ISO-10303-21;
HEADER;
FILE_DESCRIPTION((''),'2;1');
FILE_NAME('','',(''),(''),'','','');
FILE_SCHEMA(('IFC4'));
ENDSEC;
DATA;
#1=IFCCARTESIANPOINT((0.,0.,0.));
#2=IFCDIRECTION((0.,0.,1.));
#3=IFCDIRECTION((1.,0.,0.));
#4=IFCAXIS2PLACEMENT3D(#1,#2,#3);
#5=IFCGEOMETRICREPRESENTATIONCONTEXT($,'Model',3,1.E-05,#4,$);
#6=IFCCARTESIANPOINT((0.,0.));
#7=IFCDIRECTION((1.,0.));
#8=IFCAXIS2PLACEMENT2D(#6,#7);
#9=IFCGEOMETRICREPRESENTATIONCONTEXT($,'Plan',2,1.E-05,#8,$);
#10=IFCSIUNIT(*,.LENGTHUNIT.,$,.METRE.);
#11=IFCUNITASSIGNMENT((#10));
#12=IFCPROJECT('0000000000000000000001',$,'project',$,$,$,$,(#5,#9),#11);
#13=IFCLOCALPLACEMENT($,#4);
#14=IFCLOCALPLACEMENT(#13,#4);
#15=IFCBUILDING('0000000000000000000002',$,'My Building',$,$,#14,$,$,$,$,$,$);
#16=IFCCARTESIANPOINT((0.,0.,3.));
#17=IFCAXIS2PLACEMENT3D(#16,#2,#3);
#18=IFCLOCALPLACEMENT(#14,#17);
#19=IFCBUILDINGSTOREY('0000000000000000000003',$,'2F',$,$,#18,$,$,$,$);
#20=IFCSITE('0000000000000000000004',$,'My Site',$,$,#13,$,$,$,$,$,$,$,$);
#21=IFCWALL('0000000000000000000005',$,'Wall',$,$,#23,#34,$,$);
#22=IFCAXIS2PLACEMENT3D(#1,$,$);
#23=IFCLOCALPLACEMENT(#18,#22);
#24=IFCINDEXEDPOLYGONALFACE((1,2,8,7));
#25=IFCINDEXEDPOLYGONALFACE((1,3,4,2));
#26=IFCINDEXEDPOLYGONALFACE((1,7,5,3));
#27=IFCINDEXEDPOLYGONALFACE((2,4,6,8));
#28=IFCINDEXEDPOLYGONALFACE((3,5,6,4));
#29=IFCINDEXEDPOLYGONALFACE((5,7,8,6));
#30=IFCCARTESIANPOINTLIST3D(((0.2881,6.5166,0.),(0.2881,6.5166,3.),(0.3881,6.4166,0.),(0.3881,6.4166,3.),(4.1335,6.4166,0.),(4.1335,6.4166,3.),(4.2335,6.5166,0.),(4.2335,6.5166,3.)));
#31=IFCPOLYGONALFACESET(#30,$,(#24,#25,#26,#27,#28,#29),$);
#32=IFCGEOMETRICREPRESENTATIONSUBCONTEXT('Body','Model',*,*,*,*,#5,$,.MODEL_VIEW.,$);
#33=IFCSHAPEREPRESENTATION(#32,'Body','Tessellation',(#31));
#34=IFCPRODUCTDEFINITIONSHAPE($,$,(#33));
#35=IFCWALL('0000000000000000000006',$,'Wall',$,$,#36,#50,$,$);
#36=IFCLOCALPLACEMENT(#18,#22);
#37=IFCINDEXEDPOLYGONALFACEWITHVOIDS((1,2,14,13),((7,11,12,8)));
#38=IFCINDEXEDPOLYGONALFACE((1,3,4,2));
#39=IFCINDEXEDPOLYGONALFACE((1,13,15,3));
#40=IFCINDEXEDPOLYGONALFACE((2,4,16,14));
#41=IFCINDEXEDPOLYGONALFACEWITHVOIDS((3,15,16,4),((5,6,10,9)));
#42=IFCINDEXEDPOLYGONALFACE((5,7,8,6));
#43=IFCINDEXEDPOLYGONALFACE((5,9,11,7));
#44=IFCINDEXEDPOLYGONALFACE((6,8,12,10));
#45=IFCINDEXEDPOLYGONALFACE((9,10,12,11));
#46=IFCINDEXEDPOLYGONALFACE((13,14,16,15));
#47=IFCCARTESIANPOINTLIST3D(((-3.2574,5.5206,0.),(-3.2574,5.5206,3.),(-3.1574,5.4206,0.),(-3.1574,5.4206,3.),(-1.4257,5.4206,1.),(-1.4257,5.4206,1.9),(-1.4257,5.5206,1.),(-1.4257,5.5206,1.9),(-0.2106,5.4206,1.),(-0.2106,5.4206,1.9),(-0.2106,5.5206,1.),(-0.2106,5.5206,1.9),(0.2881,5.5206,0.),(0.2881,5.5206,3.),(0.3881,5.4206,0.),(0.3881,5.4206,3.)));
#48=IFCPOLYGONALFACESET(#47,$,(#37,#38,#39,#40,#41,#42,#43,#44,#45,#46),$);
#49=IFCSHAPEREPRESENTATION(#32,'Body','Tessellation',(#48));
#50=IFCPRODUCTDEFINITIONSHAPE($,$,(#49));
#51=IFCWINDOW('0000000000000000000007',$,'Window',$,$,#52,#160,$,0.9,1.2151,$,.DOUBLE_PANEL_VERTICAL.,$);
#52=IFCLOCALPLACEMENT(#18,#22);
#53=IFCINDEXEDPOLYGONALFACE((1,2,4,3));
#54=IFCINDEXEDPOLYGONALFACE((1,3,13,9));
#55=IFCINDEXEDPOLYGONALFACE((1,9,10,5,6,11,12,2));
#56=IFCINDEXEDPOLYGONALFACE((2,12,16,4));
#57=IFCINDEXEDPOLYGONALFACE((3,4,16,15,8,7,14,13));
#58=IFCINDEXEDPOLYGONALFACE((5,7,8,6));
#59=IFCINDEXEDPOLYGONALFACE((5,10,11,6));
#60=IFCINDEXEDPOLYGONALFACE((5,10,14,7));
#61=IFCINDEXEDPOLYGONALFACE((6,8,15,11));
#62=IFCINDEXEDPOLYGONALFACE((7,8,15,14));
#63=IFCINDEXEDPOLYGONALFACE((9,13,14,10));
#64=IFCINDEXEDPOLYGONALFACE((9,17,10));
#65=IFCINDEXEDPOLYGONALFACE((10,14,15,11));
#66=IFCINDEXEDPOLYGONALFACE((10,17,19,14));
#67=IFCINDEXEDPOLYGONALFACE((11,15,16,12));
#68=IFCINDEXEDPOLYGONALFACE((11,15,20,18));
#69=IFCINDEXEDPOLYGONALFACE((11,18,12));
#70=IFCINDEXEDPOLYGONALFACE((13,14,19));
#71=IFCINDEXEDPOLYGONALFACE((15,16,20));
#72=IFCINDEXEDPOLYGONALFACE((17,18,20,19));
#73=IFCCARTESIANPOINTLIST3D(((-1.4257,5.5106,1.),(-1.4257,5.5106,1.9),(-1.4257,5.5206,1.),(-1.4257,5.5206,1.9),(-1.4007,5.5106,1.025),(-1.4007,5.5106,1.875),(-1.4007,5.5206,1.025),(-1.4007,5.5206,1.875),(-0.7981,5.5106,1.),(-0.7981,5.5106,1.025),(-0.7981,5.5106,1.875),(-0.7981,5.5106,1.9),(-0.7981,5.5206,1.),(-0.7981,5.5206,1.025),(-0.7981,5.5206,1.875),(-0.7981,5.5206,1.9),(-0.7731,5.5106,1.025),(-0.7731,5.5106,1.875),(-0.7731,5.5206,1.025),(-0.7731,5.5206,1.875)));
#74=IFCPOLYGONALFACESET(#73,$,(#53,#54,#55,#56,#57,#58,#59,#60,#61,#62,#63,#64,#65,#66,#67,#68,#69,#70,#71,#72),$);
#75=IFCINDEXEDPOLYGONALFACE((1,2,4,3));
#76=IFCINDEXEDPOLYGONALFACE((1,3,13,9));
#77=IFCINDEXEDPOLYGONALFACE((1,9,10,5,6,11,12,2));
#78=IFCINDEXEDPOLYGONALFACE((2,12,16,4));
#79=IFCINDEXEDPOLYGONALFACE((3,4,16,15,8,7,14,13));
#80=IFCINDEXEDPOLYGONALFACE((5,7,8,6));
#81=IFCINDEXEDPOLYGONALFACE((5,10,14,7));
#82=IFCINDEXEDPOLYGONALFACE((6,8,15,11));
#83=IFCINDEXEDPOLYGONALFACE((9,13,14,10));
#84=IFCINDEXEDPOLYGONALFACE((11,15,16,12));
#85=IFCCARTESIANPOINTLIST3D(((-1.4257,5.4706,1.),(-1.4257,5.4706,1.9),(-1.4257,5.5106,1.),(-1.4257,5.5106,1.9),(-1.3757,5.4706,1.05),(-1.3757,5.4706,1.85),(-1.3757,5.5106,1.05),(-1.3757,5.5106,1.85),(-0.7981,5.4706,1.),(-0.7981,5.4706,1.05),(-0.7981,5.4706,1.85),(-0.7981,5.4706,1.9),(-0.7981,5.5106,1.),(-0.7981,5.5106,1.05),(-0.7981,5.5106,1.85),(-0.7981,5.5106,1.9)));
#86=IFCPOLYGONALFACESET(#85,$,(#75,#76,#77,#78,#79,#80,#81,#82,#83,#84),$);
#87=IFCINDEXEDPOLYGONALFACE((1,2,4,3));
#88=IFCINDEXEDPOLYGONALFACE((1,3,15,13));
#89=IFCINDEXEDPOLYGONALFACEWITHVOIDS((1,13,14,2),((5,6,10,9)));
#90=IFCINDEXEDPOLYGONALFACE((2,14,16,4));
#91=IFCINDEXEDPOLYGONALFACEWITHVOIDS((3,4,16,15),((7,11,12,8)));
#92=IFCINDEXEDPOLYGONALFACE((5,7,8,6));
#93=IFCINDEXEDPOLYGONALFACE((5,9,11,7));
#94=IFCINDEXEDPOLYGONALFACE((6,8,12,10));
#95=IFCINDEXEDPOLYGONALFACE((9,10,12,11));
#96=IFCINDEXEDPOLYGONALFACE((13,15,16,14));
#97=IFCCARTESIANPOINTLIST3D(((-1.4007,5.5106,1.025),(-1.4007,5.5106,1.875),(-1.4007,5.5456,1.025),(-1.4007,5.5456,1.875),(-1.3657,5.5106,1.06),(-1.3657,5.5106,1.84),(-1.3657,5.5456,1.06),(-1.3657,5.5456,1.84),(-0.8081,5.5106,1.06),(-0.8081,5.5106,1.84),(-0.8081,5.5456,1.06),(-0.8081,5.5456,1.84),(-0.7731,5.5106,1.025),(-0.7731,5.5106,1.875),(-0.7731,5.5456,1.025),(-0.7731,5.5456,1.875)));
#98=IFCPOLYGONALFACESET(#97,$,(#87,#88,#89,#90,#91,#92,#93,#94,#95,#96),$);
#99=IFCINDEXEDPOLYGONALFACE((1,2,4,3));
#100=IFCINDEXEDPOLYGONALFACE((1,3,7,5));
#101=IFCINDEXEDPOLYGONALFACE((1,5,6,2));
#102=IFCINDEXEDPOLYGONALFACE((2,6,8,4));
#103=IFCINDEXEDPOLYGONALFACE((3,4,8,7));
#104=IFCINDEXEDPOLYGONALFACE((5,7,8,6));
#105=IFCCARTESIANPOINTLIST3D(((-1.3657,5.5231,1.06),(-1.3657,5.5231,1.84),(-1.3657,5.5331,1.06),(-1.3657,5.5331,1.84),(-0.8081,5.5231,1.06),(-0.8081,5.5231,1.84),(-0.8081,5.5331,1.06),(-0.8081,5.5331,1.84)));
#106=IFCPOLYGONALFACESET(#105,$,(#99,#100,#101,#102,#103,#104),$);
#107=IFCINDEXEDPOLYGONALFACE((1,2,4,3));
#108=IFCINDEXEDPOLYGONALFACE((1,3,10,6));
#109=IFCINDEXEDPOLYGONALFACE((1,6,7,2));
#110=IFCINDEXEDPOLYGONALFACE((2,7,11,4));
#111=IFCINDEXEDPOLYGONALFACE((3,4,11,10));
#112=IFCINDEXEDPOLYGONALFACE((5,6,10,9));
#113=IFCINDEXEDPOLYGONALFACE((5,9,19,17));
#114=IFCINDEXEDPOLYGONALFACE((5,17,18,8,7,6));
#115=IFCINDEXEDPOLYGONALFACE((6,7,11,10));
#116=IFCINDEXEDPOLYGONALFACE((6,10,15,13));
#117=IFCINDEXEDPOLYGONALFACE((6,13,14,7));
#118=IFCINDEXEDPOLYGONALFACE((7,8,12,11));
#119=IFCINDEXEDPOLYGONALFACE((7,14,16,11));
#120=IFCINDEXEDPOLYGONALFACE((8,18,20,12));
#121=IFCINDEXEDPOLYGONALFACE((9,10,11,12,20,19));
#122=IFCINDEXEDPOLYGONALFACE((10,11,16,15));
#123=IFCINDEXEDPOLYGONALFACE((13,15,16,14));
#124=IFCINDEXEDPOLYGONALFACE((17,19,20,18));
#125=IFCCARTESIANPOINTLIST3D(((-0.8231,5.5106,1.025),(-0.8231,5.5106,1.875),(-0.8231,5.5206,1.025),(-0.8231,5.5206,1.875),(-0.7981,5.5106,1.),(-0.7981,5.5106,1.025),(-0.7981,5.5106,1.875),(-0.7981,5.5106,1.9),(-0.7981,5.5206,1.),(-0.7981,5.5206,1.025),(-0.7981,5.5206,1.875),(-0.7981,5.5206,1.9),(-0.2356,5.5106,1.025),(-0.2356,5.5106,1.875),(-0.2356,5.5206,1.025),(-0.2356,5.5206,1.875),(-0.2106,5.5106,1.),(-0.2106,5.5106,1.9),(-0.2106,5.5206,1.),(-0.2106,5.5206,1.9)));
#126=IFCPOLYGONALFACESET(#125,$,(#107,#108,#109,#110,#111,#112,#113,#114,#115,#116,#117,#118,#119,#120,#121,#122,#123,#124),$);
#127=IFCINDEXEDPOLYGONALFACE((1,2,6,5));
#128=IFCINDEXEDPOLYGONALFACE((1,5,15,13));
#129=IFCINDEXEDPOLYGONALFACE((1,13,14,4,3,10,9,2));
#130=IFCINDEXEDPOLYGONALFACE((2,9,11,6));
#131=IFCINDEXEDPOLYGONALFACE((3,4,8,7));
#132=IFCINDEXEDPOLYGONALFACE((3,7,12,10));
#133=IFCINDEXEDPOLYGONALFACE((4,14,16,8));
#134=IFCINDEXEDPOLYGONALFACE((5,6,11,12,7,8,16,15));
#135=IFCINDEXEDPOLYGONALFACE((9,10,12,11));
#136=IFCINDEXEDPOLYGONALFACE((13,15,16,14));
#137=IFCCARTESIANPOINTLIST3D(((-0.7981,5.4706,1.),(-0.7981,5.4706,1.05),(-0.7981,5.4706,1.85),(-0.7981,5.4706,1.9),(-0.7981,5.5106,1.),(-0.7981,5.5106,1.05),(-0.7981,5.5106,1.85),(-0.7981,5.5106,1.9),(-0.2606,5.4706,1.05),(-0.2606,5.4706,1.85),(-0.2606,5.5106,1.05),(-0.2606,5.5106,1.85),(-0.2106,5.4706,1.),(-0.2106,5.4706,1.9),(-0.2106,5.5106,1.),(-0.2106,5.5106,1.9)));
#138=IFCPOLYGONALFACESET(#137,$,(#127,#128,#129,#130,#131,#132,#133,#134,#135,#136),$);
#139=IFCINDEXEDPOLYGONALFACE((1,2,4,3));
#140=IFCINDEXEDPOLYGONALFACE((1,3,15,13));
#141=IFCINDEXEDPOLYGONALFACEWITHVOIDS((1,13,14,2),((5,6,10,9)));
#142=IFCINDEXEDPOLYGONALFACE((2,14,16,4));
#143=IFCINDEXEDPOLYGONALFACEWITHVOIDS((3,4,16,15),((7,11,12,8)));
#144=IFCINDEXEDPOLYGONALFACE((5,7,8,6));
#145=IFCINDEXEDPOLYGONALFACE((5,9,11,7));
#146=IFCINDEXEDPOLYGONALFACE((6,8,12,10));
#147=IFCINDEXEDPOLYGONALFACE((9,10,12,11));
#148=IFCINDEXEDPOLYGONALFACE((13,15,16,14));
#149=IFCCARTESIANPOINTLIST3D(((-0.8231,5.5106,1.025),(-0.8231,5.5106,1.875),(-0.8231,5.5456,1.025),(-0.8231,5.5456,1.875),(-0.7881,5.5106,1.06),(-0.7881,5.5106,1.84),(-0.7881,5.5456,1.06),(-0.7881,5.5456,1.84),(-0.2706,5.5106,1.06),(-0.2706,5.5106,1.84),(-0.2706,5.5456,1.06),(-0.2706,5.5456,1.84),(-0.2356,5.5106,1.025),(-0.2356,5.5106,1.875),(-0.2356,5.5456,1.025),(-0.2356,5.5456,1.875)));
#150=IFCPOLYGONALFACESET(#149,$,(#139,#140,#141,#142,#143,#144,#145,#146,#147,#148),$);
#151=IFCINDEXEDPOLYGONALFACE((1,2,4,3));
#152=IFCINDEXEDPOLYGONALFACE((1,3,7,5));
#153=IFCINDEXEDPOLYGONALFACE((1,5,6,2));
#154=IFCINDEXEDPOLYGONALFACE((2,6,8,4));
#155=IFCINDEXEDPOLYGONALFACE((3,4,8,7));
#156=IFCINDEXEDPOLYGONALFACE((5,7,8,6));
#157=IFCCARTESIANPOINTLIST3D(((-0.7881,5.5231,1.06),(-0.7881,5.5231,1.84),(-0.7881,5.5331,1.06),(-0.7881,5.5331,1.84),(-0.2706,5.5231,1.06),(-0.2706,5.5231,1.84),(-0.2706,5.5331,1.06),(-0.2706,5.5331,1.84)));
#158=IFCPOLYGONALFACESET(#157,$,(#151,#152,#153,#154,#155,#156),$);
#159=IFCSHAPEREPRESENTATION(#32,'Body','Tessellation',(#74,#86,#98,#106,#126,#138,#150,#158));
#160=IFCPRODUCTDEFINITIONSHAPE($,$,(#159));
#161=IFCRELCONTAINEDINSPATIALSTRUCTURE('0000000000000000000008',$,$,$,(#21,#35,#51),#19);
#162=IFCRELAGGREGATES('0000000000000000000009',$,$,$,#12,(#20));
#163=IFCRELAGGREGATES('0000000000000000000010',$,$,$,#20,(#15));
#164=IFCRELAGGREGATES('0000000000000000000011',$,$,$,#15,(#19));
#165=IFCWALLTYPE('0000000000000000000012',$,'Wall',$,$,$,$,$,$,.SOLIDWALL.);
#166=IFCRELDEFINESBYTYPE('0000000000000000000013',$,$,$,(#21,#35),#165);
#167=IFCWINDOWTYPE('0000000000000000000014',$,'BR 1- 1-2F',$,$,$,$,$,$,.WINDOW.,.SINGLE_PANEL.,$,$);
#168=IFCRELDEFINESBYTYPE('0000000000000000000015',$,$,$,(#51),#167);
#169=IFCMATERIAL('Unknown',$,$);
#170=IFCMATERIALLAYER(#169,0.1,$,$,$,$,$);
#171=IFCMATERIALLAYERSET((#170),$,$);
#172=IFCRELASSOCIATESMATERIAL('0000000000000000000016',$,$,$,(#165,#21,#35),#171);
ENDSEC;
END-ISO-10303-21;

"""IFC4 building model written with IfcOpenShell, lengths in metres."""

from ifc_helpers import new_model, entity, si_unit, frame, origin_with_axes, origin_2d_with_axis, place, context, subcontext, project, spatial, line, indexed_curve, outline, extrude, shape, source, transform, mapped, material, layer, layer_set, layer_usage, type_object, type_shapes, element, fill, save


model = new_model("IFC4")

# Units and contexts
model_context = context("Model", 3, precision=1e-05, world=origin_with_axes())
plan_context = context("Plan", 2, precision=1e-05, world=origin_2d_with_axis())
body_context_1 = subcontext(model_context, "Body", "Model", "MODEL_VIEW")
body_context_2 = subcontext(plan_context, "Body", "Plan", "PLAN_VIEW")
ifc_project = project(units=[si_unit("LENGTHUNIT", "METRE")], contexts=[model_context, plan_context])

# Site, building, storey
site_placement = place(None, origin_with_axes())
site = spatial("IfcSite", under=ifc_project, at=site_placement, Name="My Site")
building_placement = place(site_placement, origin_with_axes())
building = spatial("IfcBuilding", under=site, at=building_placement, Name="My Building")
storey_placement = place(building_placement, frame((0.0, 0.0, 3.0), z_axis=(0.0, 0.0, 1.0), x_axis=(1.0, 0.0, 0.0)))
storey = spatial("IfcBuildingStorey", under=building, at=storey_placement, Name="2F")

# Shared definitions
ifc_material = material(Name="Unknown")

# Wall
ifc_layer = layer(ifc_material, 0.1)
ifc_layer_set = layer_set([ifc_layer])
ifc_layer_usage_1 = layer_usage(ifc_layer_set, "AXIS2", "POSITIVE", 0.0)
wall_type = type_object("IfcWallType", Name="Wall", PredefinedType="SOLIDWALL", material=ifc_layer_set)
wall_1_placement = place(storey_placement, frame((4.2335, 6.5166, 0.0), z_axis=(0.0, 0.0, 1.0), x_axis=(-1.0, 0.0, 0.0)))
element("IfcWall", 1, at=wall_1_placement, inside=storey, type_object=wall_type, material=ifc_layer_usage_1, Name="Wall", context=body_context_1, shape_type="SweptSolid", body=[
    extrude(outline(indexed_curve([(0.0, 0.0), (0.1, 0.1), (3.8454, 0.1), (3.9454, 0.0)], segments=[line(1, 2, 3, 4, 1)])), origin_with_axes(), (0.0, 0.0, 1.0), 3.0),
])

# Wall, opening, window
ifc_layer_usage_2 = layer_usage(ifc_layer_set, "AXIS2", "POSITIVE", 0.0)
wall_2_placement = place(storey_placement, frame((0.3881, 5.5206, 0.0), z_axis=(0.0, 0.0, 1.0), x_axis=(-1.0, 0.0, 0.0)))
wall_2 = element("IfcWall", 2, at=wall_2_placement, inside=storey, type_object=wall_type, material=ifc_layer_usage_2, Name="Wall", context=body_context_1, shape_type="SweptSolid", body=[
    extrude(outline(indexed_curve([(0.1, 0.0), (0.0, 0.1), (3.5455, 0.1), (3.6455, 0.0)], segments=[line(1, 2, 3, 4, 1)])), origin_with_axes(), (0.0, 0.0, 1.0), 3.0),
])
shared_shape_1 = source(origin_with_axes(), body_context_1, "Body", "SweptSolid", [
    extrude(outline(indexed_curve([(0.0, 0.0), (1.2151, 0.0), (1.2151, 0.9), (0.0, 0.9)], segments=[line(1, 2, 3, 4, 1)])), frame((0.0, -0.6, 0.0), z_axis=(0.0, -1.0, 0.0), x_axis=(1.0, 0.0, 0.0)), (0.0, 0.0, -1.0), 1.2),
])
opening_1_placement = place(wall_2_placement, frame((1.8138, 0.1, 1.0), z_axis=(0.0, 0.0, 1.0), x_axis=(-1.0, 0.0, 0.0)))
opening_1 = element("IfcOpeningElement", 3, at=opening_1_placement, cuts=wall_2, PredefinedType="OPENING", context=body_context_1, shape_type="MappedRepresentation", body=[
    mapped(shared_shape_1, transform((0.0, 0.0, 0.0), x_axis=(1.0, 0.0, 0.0), y_axis=(0.0, 1.0, 0.0), z_axis=(0.0, 0.0, 1.0), scale=1.0)),
])
window_type_1 = type_object("IfcWindowType", Name="BR 1- 1-2F", PartitioningType="SINGLE_PANEL", PredefinedType="WINDOW")
shared_shape_2 = source(origin_with_axes(), body_context_1, "Body", "SweptSolid", [
    extrude(outline(indexed_curve([(0.0, 0.0), (0.6275, 0.0), (0.6275, 0.9), (0.0, 0.9)], segments=[line(1, 2, 3, 4, 1)]), holes=[indexed_curve([(0.025, 0.025), (0.6525, 0.025), (0.6525, 0.875), (0.025, 0.875)], segments=[line(1, 2, 3, 4, 1)])]), frame((0.0, 0.09, 0.0), z_axis=(0.0, -1.0, 0.0), x_axis=(1.0, 0.0, 0.0)), (0.0, 0.0, -1.0), 0.01),
    extrude(outline(indexed_curve([(0.6275, 0.0), (0.0, 0.0), (0.0, 0.9), (0.6275, 0.9), (0.6275, 0.85), (0.05, 0.85), (0.05, 0.05), (0.6275, 0.05)], segments=[line(1, 2, 3, 4, 5, 6, 7, 8, 1)])), frame((0.0, 0.05, 0.0), z_axis=(0.0, -1.0, 0.0), x_axis=(1.0, 0.0, 0.0)), (0.0, 0.0, -1.0), 0.04),
    extrude(outline(indexed_curve([(0.0, 0.0), (0.6275, 0.0), (0.6275, 0.85), (0.0, 0.85)], segments=[line(1, 2, 3, 4, 1)]), holes=[indexed_curve([(0.035, 0.035), (0.5925, 0.035), (0.5925, 0.815), (0.035, 0.815)], segments=[line(1, 2, 3, 4, 1)])]), frame((0.025, 0.09, 0.025), z_axis=(0.0, -1.0, 0.0), x_axis=(1.0, 0.0, 0.0)), (0.0, 0.0, -1.0), 0.035),
    extrude(outline(indexed_curve([(0.035, 0.035), (0.5925, 0.035), (0.5925, 0.815), (0.035, 0.815)], segments=[line(1, 2, 3, 4, 1)])), frame((0.025, 0.1025, 0.025), z_axis=(0.0, -1.0, 0.0), x_axis=(1.0, 0.0, 0.0)), (0.0, 0.0, -1.0), 0.01),
    extrude(outline(indexed_curve([(0.0, 0.0), (0.5875, 0.0), (0.5875, 0.9), (0.0, 0.9)], segments=[line(1, 2, 3, 4, 1)]), holes=[indexed_curve([(-0.025, 0.025), (0.5625, 0.025), (0.5625, 0.875), (-0.025, 0.875)], segments=[line(1, 2, 3, 4, 1)])]), frame((0.6275, 0.09, 0.0), z_axis=(0.0, -1.0, 0.0), x_axis=(1.0, 0.0, 0.0)), (0.0, 0.0, -1.0), 0.01),
    extrude(outline(indexed_curve([(0.0, 0.9), (0.5875, 0.9), (0.5875, 0.0), (0.0, 0.0), (0.0, 0.05), (0.5375, 0.05), (0.5375, 0.85), (0.0, 0.85)], segments=[line(1, 2, 3, 4, 5, 6, 7, 8, 1)])), frame((0.6275, 0.05, 0.0), z_axis=(0.0, -1.0, 0.0), x_axis=(1.0, 0.0, 0.0)), (0.0, 0.0, -1.0), 0.04),
    extrude(outline(indexed_curve([(0.0, 0.0), (0.5875, 0.0), (0.5875, 0.85), (0.0, 0.85)], segments=[line(1, 2, 3, 4, 1)]), holes=[indexed_curve([(0.035, 0.035), (0.5525, 0.035), (0.5525, 0.815), (0.035, 0.815)], segments=[line(1, 2, 3, 4, 1)])]), frame((0.6025, 0.09, 0.025), z_axis=(0.0, -1.0, 0.0), x_axis=(1.0, 0.0, 0.0)), (0.0, 0.0, -1.0), 0.035),
    extrude(outline(indexed_curve([(0.035, 0.035), (0.5525, 0.035), (0.5525, 0.815), (0.035, 0.815)], segments=[line(1, 2, 3, 4, 1)])), frame((0.6025, 0.1025, 0.025), z_axis=(0.0, -1.0, 0.0), x_axis=(1.0, 0.0, 0.0)), (0.0, 0.0, -1.0), 0.01),
])
shared_shape_3 = source(origin_with_axes(), body_context_2, "Body", "Curve2D", [
    entity("IfcIndexedPolyCurve", entity("IfcCartesianPointList2D", [[0.05, 0.05], [0.6275, 0.05]])),
    entity("IfcIndexedPolyCurve", entity("IfcCartesianPointList2D", [[0.0, 0.1], [0.025, 0.1], [0.025, 0.09], [0.05, 0.09], [0.05, 0.05], [0.0, 0.05]]), [entity("IfcLineIndex", [1, 2, 3, 4, 5, 6, 1])]),
    entity("IfcIndexedPolyCurve", entity("IfcCartesianPointList2D", [[0.6275, 0.1], [0.6525, 0.1], [0.6525, 0.09], [0.6275, 0.09], [0.6275, 0.05], [0.6275, 0.05]])),
    entity("IfcIndexedPolyCurve", entity("IfcCartesianPointList2D", [[0.025, 0.09], [0.06, 0.09], [0.06, 0.125], [0.025, 0.125]]), [entity("IfcLineIndex", [1, 2, 3, 4, 1])]),
    entity("IfcIndexedPolyCurve", entity("IfcCartesianPointList2D", [[0.6525, 0.09], [0.6175, 0.09], [0.6175, 0.125], [0.6525, 0.125]]), [entity("IfcLineIndex", [1, 2, 3, 4, 1])]),
    entity("IfcIndexedPolyCurve", entity("IfcCartesianPointList2D", [[0.06, 0.09], [0.6175, 0.09]])),
    entity("IfcIndexedPolyCurve", entity("IfcCartesianPointList2D", [[0.06, 0.125], [0.6175, 0.125]])),
    entity("IfcIndexedPolyCurve", entity("IfcCartesianPointList2D", [[0.06, 0.1075], [0.6175, 0.1075]])),
    entity("IfcIndexedPolyCurve", entity("IfcCartesianPointList2D", [[0.6275, 0.05], [1.1651, 0.05]])),
    entity("IfcIndexedPolyCurve", entity("IfcCartesianPointList2D", [[0.6275, 0.1], [0.6025, 0.1], [0.6025, 0.09], [0.6275, 0.09], [0.6275, 0.05], [0.6275, 0.05]])),
    entity("IfcIndexedPolyCurve", entity("IfcCartesianPointList2D", [[1.2151, 0.1], [1.1901, 0.1], [1.1901, 0.09], [1.1651, 0.09], [1.1651, 0.05], [1.2151, 0.05]]), [entity("IfcLineIndex", [1, 2, 3, 4, 5, 6, 1])]),
    entity("IfcIndexedPolyCurve", entity("IfcCartesianPointList2D", [[0.6025, 0.09], [0.6375, 0.09], [0.6375, 0.125], [0.6025, 0.125]]), [entity("IfcLineIndex", [1, 2, 3, 4, 1])]),
    entity("IfcIndexedPolyCurve", entity("IfcCartesianPointList2D", [[1.1901, 0.09], [1.1551, 0.09], [1.1551, 0.125], [1.1901, 0.125]]), [entity("IfcLineIndex", [1, 2, 3, 4, 1])]),
    entity("IfcIndexedPolyCurve", entity("IfcCartesianPointList2D", [[0.6375, 0.09], [1.1551, 0.09]])),
    entity("IfcIndexedPolyCurve", entity("IfcCartesianPointList2D", [[0.6375, 0.125], [1.1551, 0.125]])),
    entity("IfcIndexedPolyCurve", entity("IfcCartesianPointList2D", [[0.6375, 0.1075], [1.1551, 0.1075]])),
])
type_shapes(window_type_1, [shared_shape_2, shared_shape_3])
window_1_placement = place(opening_1_placement, frame((0.0, 0.0, 0.0), z_axis=(0.0, 0.0, 1.0), x_axis=(1.0, 0.0, 0.0)))
window_1 = element("IfcWindow", 4, at=window_1_placement, inside=storey, type_object=window_type_1, Name="Window", OverallHeight=0.9, OverallWidth=1.2151, PartitioningType="DOUBLE_PANEL_VERTICAL", shapes=[
    shape(body_context_1, "Body", "MappedRepresentation", [mapped(shared_shape_2, transform((0.0, 0.0, 0.0), x_axis=(1.0, 0.0, 0.0), y_axis=(0.0, 1.0, 0.0), z_axis=(0.0, 0.0, 1.0), scale=1.0))]),
    shape(body_context_2, "Body", "MappedRepresentation", [mapped(shared_shape_3, transform((0.0, 0.0, 0.0), x_axis=(1.0, 0.0, 0.0), y_axis=(0.0, 1.0, 0.0), z_axis=(0.0, 0.0, 1.0), scale=1.0))]),
])
fill(opening_1, window_1)

save(model, "model.ifc")
